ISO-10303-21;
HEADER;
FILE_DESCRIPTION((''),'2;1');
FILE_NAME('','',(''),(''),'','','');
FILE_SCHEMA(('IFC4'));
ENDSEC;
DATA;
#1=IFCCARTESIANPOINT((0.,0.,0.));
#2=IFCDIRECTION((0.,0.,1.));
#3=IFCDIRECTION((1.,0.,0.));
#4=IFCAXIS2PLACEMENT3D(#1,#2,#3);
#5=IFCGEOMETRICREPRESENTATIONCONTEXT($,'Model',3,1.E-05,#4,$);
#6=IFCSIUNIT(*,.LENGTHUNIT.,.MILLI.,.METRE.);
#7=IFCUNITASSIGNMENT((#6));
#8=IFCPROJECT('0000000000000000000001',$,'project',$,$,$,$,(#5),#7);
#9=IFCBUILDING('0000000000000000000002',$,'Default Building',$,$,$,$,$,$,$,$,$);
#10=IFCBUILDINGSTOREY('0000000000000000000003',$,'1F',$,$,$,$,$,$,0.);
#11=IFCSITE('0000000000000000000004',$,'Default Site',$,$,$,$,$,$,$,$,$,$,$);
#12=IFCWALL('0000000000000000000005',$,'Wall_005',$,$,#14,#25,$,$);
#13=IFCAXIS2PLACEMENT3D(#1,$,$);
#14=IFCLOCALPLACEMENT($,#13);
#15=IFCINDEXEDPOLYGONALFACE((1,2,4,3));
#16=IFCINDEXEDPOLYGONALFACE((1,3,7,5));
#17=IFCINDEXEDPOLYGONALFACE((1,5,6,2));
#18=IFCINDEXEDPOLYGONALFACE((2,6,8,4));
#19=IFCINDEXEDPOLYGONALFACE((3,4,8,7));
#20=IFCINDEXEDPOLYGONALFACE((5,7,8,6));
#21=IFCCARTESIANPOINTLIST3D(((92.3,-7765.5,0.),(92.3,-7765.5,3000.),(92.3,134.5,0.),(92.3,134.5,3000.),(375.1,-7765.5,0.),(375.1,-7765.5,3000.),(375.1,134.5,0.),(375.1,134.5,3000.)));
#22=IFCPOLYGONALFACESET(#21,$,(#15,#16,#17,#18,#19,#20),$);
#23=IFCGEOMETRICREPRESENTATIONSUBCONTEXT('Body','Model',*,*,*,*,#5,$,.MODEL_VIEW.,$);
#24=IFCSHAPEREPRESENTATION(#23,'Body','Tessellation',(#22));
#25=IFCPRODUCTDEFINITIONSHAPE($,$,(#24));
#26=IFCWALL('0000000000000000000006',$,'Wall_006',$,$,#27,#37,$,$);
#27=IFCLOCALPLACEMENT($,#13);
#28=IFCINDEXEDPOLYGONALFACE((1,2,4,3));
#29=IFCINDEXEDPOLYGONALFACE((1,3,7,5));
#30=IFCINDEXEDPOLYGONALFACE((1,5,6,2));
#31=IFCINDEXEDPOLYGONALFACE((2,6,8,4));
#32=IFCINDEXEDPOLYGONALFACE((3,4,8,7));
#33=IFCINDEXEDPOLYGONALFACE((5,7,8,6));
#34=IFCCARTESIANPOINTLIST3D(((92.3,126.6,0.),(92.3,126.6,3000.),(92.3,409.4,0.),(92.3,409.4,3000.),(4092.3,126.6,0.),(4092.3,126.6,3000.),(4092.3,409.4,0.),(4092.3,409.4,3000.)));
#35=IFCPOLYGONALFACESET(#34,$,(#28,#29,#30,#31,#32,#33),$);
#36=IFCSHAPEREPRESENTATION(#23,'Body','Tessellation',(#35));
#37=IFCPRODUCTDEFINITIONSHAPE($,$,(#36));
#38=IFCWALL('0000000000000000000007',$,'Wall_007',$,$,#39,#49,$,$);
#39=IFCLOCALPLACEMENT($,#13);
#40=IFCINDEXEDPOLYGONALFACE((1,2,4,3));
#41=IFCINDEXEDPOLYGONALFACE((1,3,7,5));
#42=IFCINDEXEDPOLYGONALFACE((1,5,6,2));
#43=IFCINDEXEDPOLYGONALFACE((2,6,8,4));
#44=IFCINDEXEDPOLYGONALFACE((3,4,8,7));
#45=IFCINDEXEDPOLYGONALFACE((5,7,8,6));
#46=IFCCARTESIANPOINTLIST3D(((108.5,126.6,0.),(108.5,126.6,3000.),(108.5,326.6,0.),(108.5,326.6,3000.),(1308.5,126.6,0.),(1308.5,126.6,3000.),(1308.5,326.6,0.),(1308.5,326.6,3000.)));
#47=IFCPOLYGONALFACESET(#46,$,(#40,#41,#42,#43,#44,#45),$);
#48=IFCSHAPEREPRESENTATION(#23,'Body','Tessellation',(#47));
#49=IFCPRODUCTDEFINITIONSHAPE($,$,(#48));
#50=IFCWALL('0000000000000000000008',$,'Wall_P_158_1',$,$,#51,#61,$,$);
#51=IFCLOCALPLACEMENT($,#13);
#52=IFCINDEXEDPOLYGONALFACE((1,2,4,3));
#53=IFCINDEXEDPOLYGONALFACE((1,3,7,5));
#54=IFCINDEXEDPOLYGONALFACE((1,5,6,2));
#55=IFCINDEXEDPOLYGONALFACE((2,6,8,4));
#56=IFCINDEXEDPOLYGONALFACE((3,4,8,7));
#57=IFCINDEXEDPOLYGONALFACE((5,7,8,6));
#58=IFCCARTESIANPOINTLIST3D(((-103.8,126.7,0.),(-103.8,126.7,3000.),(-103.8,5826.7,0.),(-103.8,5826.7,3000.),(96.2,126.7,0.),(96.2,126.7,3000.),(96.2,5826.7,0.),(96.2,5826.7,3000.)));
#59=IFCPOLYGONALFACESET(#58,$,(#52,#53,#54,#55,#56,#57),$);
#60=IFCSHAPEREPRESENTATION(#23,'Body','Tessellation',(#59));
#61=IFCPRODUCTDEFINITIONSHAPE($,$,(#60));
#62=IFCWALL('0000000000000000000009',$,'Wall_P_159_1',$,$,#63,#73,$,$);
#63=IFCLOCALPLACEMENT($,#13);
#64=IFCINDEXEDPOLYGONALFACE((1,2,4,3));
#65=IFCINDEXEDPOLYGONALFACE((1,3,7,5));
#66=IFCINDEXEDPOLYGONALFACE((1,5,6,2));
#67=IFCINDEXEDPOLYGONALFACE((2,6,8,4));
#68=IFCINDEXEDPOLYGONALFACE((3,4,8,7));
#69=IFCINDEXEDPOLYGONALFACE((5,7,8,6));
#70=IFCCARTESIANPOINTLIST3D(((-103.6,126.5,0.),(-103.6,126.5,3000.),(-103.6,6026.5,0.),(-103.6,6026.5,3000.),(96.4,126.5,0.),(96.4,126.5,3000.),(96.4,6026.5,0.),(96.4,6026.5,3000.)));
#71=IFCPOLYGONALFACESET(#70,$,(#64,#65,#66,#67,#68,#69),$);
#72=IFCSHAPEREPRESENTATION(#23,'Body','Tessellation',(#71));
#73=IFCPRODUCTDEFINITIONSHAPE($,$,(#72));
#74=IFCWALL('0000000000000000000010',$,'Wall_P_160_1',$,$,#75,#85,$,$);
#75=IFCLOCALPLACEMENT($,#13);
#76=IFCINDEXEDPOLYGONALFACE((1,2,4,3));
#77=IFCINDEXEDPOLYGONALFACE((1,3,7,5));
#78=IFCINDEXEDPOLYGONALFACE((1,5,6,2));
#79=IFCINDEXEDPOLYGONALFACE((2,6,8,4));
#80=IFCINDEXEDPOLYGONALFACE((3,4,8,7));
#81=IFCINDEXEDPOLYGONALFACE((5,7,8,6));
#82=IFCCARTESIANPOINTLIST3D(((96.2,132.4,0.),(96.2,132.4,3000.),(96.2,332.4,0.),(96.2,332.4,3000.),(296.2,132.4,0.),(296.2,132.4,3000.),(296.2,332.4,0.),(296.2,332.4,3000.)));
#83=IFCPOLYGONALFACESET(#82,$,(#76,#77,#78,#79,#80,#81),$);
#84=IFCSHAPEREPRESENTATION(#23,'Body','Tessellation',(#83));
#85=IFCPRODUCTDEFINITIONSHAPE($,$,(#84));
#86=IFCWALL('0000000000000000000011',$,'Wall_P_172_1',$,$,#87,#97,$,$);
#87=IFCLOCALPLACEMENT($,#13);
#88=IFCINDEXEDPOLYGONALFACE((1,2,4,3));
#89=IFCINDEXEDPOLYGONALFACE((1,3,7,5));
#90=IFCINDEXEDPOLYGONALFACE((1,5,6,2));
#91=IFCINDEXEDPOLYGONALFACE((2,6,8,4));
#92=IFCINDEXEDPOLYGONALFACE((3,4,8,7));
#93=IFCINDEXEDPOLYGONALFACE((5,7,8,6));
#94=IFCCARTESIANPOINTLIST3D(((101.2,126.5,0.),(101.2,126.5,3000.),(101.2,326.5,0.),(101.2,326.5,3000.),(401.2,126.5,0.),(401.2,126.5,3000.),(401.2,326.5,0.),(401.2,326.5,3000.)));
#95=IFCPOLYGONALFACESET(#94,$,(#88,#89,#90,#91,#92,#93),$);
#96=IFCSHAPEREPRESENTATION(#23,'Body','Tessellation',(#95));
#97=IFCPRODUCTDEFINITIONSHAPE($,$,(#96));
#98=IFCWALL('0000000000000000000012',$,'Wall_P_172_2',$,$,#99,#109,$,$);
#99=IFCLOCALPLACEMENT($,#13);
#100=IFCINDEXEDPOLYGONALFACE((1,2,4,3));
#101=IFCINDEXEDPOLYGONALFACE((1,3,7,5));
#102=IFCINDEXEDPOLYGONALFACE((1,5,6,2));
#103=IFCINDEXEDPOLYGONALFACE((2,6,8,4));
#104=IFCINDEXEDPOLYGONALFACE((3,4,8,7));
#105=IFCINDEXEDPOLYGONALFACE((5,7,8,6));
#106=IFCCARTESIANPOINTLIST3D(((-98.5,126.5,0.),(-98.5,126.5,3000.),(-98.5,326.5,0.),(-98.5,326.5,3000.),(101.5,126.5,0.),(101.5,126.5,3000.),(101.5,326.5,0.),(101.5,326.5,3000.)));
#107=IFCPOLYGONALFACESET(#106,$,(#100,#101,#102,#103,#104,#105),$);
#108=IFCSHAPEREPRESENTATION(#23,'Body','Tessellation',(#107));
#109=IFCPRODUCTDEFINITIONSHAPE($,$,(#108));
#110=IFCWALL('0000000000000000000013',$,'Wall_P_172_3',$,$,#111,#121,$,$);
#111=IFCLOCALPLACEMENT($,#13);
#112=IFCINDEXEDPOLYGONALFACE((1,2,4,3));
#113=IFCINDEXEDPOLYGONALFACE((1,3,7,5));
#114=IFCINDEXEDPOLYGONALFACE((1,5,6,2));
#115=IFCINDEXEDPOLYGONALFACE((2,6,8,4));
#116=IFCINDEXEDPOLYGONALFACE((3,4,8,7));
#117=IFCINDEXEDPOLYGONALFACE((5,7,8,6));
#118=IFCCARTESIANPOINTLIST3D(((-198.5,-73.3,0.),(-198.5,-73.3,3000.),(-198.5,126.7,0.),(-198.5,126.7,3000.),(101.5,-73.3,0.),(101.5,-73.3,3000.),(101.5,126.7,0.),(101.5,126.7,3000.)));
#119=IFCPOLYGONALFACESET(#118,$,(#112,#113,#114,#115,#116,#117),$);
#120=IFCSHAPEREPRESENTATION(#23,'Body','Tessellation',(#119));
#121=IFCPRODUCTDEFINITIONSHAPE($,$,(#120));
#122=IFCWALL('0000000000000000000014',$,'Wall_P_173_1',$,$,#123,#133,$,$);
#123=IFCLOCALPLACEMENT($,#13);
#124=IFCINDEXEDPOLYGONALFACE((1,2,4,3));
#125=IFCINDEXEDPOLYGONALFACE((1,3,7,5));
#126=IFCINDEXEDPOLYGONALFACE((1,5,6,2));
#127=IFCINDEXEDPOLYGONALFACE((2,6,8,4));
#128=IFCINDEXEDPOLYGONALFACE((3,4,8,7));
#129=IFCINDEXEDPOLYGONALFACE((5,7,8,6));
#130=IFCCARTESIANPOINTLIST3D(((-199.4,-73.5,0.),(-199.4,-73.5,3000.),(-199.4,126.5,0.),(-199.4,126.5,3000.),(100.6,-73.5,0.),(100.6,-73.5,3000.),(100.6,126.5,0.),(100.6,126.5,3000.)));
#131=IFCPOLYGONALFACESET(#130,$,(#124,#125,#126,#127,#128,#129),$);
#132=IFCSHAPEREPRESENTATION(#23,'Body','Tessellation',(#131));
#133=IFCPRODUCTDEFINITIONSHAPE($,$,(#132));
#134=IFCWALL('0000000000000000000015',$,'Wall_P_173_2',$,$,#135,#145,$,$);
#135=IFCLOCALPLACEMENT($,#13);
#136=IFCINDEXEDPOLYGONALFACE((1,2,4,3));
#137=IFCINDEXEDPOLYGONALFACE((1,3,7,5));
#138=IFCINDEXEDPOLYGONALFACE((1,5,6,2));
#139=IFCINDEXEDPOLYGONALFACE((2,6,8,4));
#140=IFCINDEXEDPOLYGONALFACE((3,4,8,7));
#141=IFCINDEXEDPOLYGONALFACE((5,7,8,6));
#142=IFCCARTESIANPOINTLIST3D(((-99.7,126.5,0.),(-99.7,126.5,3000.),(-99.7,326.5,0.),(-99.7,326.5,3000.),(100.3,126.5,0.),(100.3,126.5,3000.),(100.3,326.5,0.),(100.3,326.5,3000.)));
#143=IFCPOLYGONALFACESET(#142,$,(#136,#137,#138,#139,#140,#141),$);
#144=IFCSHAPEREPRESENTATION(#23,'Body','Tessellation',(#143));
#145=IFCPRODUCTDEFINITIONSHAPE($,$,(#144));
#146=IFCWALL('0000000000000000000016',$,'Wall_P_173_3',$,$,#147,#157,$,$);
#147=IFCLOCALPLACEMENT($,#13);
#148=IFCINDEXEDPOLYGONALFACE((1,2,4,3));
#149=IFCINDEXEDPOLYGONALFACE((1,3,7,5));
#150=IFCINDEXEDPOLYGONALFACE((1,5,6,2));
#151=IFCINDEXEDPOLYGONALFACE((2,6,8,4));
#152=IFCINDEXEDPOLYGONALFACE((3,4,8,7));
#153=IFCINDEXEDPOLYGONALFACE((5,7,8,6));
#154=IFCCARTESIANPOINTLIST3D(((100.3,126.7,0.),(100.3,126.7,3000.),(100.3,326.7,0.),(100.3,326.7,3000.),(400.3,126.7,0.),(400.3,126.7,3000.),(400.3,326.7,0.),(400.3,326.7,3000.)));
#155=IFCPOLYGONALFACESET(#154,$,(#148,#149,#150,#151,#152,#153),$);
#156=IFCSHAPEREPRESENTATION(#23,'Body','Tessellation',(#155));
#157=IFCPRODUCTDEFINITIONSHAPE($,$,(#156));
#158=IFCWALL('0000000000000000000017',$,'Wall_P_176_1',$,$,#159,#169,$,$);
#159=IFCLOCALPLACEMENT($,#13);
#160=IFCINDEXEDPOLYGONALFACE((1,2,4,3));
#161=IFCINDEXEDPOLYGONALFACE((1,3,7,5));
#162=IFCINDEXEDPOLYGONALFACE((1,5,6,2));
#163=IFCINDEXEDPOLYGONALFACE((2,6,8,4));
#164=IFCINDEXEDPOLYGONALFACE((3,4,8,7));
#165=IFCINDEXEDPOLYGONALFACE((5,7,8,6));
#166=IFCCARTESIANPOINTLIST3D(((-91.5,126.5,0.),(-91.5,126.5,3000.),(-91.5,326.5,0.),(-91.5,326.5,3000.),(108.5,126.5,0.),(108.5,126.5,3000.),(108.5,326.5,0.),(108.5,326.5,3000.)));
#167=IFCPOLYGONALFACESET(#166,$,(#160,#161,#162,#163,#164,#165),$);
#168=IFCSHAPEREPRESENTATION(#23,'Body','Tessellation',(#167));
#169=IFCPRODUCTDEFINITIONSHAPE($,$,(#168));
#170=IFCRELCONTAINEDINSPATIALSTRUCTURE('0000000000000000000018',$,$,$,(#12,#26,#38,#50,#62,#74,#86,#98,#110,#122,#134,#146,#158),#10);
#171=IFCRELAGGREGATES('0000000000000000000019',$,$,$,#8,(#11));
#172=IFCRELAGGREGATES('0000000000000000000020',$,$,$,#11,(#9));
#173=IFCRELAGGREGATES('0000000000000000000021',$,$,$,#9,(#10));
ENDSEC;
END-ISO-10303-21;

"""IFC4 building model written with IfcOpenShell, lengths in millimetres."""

from ifc_helpers import new_model, si_unit, frame, origin_with_axes, place, context, subcontext, project, spatial, indexed_curve, outline, extrude, element, save


model = new_model("IFC4")

# Units and contexts
model_context = context("Model", 3, precision=1e-05, world=origin_with_axes())
body_context = subcontext(model_context, "Body", "Model", "MODEL_VIEW")
ifc_project = project(units=[si_unit("LENGTHUNIT", "METRE", prefix="MILLI")], contexts=[model_context])

# Site, building, storey
site = spatial("IfcSite", under=ifc_project, Name="Default Site")
building = spatial("IfcBuilding", under=site, Name="Default Building")
storey = spatial("IfcBuildingStorey", under=building, Name="1F", Elevation=0.0)

# Walls
wall_1_placement = place(None, frame((92.3, 134.5, 0.0), z_axis=(0.0, 0.0, 1.0), x_axis=(0.0, -1.0, 0.0)))
element("IfcWall", 1, at=wall_1_placement, inside=storey, Name="Wall_005", context=body_context, shape_type="SweptSolid", body=[
    extrude(outline(indexed_curve([(0.0, 0.0), (0.0, 282.8), (7900.0, 282.8), (7900.0, 0.0), (0.0, 0.0)], self_intersect=False)), origin_with_axes(), (0.0, 0.0, 1.0), 3000.0),
])
wall_2_placement = place(None, frame((92.3, 126.6, 0.0), z_axis=(0.0, 0.0, 1.0), x_axis=(1.0, 0.0, 0.0)))
element("IfcWall", 2, at=wall_2_placement, inside=storey, Name="Wall_006", context=body_context, shape_type="SweptSolid", body=[
    extrude(outline(indexed_curve([(0.0, 0.0), (0.0, 282.8), (4000.0, 282.8), (4000.0, 0.0), (0.0, 0.0)], self_intersect=False)), origin_with_axes(), (0.0, 0.0, 1.0), 3000.0),
])
wall_3_placement = place(None, frame((108.5, 126.6, 0.0), z_axis=(0.0, 0.0, 1.0), x_axis=(1.0, 0.0, 0.0)))
element("IfcWall", 3, at=wall_3_placement, inside=storey, Name="Wall_007", context=body_context, shape_type="SweptSolid", body=[
    extrude(outline(indexed_curve([(0.0, 0.0), (0.0, 200.0), (1200.0, 200.0), (1200.0, 0.0), (0.0, 0.0)], self_intersect=False)), origin_with_axes(), (0.0, 0.0, 1.0), 3000.0),
])
wall_4_placement = place(None, frame((96.2, 126.7, 0.0), z_axis=(0.0, 0.0, 1.0), x_axis=(0.0, 1.0, 0.0)))
element("IfcWall", 4, at=wall_4_placement, inside=storey, Name="Wall_P_158_1", context=body_context, shape_type="SweptSolid", body=[
    extrude(outline(indexed_curve([(0.0, 0.0), (0.0, 200.0), (5700.0, 200.0), (5700.0, 0.0), (0.0, 0.0)], self_intersect=False)), origin_with_axes(), (0.0, 0.0, 1.0), 3000.0),
])
wall_5_placement = place(None, frame((96.4, 126.5, 0.0), z_axis=(0.0, 0.0, 1.0), x_axis=(0.0, 1.0, 0.0)))
element("IfcWall", 5, at=wall_5_placement, inside=storey, Name="Wall_P_159_1", context=body_context, shape_type="SweptSolid", body=[
    extrude(outline(indexed_curve([(0.0, 0.0), (0.0, 200.0), (5900.0, 200.0), (5900.0, 0.0), (0.0, 0.0)], self_intersect=False)), origin_with_axes(), (0.0, 0.0, 1.0), 3000.0),
])
wall_6_placement = place(None, frame((96.2, 132.4, 0.0), z_axis=(0.0, 0.0, 1.0), x_axis=(1.0, 0.0, 0.0)))
element("IfcWall", 6, at=wall_6_placement, inside=storey, Name="Wall_P_160_1", context=body_context, shape_type="SweptSolid", body=[
    extrude(outline(indexed_curve([(0.0, 0.0), (0.0, 200.0), (200.0, 200.0), (200.0, 0.0), (0.0, 0.0)], self_intersect=False)), origin_with_axes(), (0.0, 0.0, 1.0), 3000.0),
])
wall_7_placement = place(None, frame((101.2, 126.5, 0.0), z_axis=(0.0, 0.0, 1.0), x_axis=(1.0, 0.0, 0.0)))
element("IfcWall", 7, at=wall_7_placement, inside=storey, Name="Wall_P_172_1", context=body_context, shape_type="SweptSolid", body=[
    extrude(outline(indexed_curve([(0.0, 0.0), (0.0, 200.0), (300.0, 200.0), (300.0, 0.0), (0.0, 0.0)], self_intersect=False)), origin_with_axes(), (0.0, 0.0, 1.0), 3000.0),
])
wall_8_placement = place(None, frame((101.5, 126.5, 0.0), z_axis=(0.0, 0.0, 1.0), x_axis=(0.0, 1.0, 0.0)))
element("IfcWall", 8, at=wall_8_placement, inside=storey, Name="Wall_P_172_2", context=body_context, shape_type="SweptSolid", body=[
    extrude(outline(indexed_curve([(0.0, 0.0), (0.0, 200.0), (200.0, 200.0), (200.0, 0.0), (0.0, 0.0)], self_intersect=False)), origin_with_axes(), (0.0, 0.0, 1.0), 3000.0),
])
wall_9_placement = place(None, frame((101.5, 126.7, 0.0), z_axis=(0.0, 0.0, 1.0), x_axis=(-1.0, 0.0, 0.0)))
element("IfcWall", 9, at=wall_9_placement, inside=storey, Name="Wall_P_172_3", context=body_context, shape_type="SweptSolid", body=[
    extrude(outline(indexed_curve([(0.0, 0.0), (0.0, 200.0), (300.0, 200.0), (300.0, 0.0), (0.0, 0.0)], self_intersect=False)), origin_with_axes(), (0.0, 0.0, 1.0), 3000.0),
])
wall_10_placement = place(None, frame((100.6, 126.5, 0.0), z_axis=(0.0, 0.0, 1.0), x_axis=(-1.0, 0.0, 0.0)))
element("IfcWall", 10, at=wall_10_placement, inside=storey, Name="Wall_P_173_1", context=body_context, shape_type="SweptSolid", body=[
    extrude(outline(indexed_curve([(0.0, 0.0), (0.0, 200.0), (300.0, 200.0), (300.0, 0.0), (0.0, 0.0)], self_intersect=False)), origin_with_axes(), (0.0, 0.0, 1.0), 3000.0),
])
wall_11_placement = place(None, frame((100.3, 126.5, 0.0), z_axis=(0.0, 0.0, 1.0), x_axis=(0.0, 1.0, 0.0)))
element("IfcWall", 11, at=wall_11_placement, inside=storey, Name="Wall_P_173_2", context=body_context, shape_type="SweptSolid", body=[
    extrude(outline(indexed_curve([(0.0, 0.0), (0.0, 200.0), (200.0, 200.0), (200.0, 0.0), (0.0, 0.0)], self_intersect=False)), origin_with_axes(), (0.0, 0.0, 1.0), 3000.0),
])
wall_12_placement = place(None, frame((100.3, 126.7, 0.0), z_axis=(0.0, 0.0, 1.0), x_axis=(1.0, 0.0, 0.0)))
element("IfcWall", 12, at=wall_12_placement, inside=storey, Name="Wall_P_173_3", context=body_context, shape_type="SweptSolid", body=[
    extrude(outline(indexed_curve([(0.0, 0.0), (0.0, 200.0), (300.0, 200.0), (300.0, 0.0), (0.0, 0.0)], self_intersect=False)), origin_with_axes(), (0.0, 0.0, 1.0), 3000.0),
])
wall_13_placement = place(None, frame((108.5, 126.5, 0.0), z_axis=(0.0, 0.0, 1.0), x_axis=(0.0, 1.0, 0.0)))
element("IfcWall", 13, at=wall_13_placement, inside=storey, Name="Wall_P_176_1", context=body_context, shape_type="SweptSolid", body=[
    extrude(outline(indexed_curve([(0.0, 0.0), (0.0, 200.0), (200.0, 200.0), (200.0, 0.0), (0.0, 0.0)], self_intersect=False)), origin_with_axes(), (0.0, 0.0, 1.0), 3000.0),
])

save(model, "model.ifc")
